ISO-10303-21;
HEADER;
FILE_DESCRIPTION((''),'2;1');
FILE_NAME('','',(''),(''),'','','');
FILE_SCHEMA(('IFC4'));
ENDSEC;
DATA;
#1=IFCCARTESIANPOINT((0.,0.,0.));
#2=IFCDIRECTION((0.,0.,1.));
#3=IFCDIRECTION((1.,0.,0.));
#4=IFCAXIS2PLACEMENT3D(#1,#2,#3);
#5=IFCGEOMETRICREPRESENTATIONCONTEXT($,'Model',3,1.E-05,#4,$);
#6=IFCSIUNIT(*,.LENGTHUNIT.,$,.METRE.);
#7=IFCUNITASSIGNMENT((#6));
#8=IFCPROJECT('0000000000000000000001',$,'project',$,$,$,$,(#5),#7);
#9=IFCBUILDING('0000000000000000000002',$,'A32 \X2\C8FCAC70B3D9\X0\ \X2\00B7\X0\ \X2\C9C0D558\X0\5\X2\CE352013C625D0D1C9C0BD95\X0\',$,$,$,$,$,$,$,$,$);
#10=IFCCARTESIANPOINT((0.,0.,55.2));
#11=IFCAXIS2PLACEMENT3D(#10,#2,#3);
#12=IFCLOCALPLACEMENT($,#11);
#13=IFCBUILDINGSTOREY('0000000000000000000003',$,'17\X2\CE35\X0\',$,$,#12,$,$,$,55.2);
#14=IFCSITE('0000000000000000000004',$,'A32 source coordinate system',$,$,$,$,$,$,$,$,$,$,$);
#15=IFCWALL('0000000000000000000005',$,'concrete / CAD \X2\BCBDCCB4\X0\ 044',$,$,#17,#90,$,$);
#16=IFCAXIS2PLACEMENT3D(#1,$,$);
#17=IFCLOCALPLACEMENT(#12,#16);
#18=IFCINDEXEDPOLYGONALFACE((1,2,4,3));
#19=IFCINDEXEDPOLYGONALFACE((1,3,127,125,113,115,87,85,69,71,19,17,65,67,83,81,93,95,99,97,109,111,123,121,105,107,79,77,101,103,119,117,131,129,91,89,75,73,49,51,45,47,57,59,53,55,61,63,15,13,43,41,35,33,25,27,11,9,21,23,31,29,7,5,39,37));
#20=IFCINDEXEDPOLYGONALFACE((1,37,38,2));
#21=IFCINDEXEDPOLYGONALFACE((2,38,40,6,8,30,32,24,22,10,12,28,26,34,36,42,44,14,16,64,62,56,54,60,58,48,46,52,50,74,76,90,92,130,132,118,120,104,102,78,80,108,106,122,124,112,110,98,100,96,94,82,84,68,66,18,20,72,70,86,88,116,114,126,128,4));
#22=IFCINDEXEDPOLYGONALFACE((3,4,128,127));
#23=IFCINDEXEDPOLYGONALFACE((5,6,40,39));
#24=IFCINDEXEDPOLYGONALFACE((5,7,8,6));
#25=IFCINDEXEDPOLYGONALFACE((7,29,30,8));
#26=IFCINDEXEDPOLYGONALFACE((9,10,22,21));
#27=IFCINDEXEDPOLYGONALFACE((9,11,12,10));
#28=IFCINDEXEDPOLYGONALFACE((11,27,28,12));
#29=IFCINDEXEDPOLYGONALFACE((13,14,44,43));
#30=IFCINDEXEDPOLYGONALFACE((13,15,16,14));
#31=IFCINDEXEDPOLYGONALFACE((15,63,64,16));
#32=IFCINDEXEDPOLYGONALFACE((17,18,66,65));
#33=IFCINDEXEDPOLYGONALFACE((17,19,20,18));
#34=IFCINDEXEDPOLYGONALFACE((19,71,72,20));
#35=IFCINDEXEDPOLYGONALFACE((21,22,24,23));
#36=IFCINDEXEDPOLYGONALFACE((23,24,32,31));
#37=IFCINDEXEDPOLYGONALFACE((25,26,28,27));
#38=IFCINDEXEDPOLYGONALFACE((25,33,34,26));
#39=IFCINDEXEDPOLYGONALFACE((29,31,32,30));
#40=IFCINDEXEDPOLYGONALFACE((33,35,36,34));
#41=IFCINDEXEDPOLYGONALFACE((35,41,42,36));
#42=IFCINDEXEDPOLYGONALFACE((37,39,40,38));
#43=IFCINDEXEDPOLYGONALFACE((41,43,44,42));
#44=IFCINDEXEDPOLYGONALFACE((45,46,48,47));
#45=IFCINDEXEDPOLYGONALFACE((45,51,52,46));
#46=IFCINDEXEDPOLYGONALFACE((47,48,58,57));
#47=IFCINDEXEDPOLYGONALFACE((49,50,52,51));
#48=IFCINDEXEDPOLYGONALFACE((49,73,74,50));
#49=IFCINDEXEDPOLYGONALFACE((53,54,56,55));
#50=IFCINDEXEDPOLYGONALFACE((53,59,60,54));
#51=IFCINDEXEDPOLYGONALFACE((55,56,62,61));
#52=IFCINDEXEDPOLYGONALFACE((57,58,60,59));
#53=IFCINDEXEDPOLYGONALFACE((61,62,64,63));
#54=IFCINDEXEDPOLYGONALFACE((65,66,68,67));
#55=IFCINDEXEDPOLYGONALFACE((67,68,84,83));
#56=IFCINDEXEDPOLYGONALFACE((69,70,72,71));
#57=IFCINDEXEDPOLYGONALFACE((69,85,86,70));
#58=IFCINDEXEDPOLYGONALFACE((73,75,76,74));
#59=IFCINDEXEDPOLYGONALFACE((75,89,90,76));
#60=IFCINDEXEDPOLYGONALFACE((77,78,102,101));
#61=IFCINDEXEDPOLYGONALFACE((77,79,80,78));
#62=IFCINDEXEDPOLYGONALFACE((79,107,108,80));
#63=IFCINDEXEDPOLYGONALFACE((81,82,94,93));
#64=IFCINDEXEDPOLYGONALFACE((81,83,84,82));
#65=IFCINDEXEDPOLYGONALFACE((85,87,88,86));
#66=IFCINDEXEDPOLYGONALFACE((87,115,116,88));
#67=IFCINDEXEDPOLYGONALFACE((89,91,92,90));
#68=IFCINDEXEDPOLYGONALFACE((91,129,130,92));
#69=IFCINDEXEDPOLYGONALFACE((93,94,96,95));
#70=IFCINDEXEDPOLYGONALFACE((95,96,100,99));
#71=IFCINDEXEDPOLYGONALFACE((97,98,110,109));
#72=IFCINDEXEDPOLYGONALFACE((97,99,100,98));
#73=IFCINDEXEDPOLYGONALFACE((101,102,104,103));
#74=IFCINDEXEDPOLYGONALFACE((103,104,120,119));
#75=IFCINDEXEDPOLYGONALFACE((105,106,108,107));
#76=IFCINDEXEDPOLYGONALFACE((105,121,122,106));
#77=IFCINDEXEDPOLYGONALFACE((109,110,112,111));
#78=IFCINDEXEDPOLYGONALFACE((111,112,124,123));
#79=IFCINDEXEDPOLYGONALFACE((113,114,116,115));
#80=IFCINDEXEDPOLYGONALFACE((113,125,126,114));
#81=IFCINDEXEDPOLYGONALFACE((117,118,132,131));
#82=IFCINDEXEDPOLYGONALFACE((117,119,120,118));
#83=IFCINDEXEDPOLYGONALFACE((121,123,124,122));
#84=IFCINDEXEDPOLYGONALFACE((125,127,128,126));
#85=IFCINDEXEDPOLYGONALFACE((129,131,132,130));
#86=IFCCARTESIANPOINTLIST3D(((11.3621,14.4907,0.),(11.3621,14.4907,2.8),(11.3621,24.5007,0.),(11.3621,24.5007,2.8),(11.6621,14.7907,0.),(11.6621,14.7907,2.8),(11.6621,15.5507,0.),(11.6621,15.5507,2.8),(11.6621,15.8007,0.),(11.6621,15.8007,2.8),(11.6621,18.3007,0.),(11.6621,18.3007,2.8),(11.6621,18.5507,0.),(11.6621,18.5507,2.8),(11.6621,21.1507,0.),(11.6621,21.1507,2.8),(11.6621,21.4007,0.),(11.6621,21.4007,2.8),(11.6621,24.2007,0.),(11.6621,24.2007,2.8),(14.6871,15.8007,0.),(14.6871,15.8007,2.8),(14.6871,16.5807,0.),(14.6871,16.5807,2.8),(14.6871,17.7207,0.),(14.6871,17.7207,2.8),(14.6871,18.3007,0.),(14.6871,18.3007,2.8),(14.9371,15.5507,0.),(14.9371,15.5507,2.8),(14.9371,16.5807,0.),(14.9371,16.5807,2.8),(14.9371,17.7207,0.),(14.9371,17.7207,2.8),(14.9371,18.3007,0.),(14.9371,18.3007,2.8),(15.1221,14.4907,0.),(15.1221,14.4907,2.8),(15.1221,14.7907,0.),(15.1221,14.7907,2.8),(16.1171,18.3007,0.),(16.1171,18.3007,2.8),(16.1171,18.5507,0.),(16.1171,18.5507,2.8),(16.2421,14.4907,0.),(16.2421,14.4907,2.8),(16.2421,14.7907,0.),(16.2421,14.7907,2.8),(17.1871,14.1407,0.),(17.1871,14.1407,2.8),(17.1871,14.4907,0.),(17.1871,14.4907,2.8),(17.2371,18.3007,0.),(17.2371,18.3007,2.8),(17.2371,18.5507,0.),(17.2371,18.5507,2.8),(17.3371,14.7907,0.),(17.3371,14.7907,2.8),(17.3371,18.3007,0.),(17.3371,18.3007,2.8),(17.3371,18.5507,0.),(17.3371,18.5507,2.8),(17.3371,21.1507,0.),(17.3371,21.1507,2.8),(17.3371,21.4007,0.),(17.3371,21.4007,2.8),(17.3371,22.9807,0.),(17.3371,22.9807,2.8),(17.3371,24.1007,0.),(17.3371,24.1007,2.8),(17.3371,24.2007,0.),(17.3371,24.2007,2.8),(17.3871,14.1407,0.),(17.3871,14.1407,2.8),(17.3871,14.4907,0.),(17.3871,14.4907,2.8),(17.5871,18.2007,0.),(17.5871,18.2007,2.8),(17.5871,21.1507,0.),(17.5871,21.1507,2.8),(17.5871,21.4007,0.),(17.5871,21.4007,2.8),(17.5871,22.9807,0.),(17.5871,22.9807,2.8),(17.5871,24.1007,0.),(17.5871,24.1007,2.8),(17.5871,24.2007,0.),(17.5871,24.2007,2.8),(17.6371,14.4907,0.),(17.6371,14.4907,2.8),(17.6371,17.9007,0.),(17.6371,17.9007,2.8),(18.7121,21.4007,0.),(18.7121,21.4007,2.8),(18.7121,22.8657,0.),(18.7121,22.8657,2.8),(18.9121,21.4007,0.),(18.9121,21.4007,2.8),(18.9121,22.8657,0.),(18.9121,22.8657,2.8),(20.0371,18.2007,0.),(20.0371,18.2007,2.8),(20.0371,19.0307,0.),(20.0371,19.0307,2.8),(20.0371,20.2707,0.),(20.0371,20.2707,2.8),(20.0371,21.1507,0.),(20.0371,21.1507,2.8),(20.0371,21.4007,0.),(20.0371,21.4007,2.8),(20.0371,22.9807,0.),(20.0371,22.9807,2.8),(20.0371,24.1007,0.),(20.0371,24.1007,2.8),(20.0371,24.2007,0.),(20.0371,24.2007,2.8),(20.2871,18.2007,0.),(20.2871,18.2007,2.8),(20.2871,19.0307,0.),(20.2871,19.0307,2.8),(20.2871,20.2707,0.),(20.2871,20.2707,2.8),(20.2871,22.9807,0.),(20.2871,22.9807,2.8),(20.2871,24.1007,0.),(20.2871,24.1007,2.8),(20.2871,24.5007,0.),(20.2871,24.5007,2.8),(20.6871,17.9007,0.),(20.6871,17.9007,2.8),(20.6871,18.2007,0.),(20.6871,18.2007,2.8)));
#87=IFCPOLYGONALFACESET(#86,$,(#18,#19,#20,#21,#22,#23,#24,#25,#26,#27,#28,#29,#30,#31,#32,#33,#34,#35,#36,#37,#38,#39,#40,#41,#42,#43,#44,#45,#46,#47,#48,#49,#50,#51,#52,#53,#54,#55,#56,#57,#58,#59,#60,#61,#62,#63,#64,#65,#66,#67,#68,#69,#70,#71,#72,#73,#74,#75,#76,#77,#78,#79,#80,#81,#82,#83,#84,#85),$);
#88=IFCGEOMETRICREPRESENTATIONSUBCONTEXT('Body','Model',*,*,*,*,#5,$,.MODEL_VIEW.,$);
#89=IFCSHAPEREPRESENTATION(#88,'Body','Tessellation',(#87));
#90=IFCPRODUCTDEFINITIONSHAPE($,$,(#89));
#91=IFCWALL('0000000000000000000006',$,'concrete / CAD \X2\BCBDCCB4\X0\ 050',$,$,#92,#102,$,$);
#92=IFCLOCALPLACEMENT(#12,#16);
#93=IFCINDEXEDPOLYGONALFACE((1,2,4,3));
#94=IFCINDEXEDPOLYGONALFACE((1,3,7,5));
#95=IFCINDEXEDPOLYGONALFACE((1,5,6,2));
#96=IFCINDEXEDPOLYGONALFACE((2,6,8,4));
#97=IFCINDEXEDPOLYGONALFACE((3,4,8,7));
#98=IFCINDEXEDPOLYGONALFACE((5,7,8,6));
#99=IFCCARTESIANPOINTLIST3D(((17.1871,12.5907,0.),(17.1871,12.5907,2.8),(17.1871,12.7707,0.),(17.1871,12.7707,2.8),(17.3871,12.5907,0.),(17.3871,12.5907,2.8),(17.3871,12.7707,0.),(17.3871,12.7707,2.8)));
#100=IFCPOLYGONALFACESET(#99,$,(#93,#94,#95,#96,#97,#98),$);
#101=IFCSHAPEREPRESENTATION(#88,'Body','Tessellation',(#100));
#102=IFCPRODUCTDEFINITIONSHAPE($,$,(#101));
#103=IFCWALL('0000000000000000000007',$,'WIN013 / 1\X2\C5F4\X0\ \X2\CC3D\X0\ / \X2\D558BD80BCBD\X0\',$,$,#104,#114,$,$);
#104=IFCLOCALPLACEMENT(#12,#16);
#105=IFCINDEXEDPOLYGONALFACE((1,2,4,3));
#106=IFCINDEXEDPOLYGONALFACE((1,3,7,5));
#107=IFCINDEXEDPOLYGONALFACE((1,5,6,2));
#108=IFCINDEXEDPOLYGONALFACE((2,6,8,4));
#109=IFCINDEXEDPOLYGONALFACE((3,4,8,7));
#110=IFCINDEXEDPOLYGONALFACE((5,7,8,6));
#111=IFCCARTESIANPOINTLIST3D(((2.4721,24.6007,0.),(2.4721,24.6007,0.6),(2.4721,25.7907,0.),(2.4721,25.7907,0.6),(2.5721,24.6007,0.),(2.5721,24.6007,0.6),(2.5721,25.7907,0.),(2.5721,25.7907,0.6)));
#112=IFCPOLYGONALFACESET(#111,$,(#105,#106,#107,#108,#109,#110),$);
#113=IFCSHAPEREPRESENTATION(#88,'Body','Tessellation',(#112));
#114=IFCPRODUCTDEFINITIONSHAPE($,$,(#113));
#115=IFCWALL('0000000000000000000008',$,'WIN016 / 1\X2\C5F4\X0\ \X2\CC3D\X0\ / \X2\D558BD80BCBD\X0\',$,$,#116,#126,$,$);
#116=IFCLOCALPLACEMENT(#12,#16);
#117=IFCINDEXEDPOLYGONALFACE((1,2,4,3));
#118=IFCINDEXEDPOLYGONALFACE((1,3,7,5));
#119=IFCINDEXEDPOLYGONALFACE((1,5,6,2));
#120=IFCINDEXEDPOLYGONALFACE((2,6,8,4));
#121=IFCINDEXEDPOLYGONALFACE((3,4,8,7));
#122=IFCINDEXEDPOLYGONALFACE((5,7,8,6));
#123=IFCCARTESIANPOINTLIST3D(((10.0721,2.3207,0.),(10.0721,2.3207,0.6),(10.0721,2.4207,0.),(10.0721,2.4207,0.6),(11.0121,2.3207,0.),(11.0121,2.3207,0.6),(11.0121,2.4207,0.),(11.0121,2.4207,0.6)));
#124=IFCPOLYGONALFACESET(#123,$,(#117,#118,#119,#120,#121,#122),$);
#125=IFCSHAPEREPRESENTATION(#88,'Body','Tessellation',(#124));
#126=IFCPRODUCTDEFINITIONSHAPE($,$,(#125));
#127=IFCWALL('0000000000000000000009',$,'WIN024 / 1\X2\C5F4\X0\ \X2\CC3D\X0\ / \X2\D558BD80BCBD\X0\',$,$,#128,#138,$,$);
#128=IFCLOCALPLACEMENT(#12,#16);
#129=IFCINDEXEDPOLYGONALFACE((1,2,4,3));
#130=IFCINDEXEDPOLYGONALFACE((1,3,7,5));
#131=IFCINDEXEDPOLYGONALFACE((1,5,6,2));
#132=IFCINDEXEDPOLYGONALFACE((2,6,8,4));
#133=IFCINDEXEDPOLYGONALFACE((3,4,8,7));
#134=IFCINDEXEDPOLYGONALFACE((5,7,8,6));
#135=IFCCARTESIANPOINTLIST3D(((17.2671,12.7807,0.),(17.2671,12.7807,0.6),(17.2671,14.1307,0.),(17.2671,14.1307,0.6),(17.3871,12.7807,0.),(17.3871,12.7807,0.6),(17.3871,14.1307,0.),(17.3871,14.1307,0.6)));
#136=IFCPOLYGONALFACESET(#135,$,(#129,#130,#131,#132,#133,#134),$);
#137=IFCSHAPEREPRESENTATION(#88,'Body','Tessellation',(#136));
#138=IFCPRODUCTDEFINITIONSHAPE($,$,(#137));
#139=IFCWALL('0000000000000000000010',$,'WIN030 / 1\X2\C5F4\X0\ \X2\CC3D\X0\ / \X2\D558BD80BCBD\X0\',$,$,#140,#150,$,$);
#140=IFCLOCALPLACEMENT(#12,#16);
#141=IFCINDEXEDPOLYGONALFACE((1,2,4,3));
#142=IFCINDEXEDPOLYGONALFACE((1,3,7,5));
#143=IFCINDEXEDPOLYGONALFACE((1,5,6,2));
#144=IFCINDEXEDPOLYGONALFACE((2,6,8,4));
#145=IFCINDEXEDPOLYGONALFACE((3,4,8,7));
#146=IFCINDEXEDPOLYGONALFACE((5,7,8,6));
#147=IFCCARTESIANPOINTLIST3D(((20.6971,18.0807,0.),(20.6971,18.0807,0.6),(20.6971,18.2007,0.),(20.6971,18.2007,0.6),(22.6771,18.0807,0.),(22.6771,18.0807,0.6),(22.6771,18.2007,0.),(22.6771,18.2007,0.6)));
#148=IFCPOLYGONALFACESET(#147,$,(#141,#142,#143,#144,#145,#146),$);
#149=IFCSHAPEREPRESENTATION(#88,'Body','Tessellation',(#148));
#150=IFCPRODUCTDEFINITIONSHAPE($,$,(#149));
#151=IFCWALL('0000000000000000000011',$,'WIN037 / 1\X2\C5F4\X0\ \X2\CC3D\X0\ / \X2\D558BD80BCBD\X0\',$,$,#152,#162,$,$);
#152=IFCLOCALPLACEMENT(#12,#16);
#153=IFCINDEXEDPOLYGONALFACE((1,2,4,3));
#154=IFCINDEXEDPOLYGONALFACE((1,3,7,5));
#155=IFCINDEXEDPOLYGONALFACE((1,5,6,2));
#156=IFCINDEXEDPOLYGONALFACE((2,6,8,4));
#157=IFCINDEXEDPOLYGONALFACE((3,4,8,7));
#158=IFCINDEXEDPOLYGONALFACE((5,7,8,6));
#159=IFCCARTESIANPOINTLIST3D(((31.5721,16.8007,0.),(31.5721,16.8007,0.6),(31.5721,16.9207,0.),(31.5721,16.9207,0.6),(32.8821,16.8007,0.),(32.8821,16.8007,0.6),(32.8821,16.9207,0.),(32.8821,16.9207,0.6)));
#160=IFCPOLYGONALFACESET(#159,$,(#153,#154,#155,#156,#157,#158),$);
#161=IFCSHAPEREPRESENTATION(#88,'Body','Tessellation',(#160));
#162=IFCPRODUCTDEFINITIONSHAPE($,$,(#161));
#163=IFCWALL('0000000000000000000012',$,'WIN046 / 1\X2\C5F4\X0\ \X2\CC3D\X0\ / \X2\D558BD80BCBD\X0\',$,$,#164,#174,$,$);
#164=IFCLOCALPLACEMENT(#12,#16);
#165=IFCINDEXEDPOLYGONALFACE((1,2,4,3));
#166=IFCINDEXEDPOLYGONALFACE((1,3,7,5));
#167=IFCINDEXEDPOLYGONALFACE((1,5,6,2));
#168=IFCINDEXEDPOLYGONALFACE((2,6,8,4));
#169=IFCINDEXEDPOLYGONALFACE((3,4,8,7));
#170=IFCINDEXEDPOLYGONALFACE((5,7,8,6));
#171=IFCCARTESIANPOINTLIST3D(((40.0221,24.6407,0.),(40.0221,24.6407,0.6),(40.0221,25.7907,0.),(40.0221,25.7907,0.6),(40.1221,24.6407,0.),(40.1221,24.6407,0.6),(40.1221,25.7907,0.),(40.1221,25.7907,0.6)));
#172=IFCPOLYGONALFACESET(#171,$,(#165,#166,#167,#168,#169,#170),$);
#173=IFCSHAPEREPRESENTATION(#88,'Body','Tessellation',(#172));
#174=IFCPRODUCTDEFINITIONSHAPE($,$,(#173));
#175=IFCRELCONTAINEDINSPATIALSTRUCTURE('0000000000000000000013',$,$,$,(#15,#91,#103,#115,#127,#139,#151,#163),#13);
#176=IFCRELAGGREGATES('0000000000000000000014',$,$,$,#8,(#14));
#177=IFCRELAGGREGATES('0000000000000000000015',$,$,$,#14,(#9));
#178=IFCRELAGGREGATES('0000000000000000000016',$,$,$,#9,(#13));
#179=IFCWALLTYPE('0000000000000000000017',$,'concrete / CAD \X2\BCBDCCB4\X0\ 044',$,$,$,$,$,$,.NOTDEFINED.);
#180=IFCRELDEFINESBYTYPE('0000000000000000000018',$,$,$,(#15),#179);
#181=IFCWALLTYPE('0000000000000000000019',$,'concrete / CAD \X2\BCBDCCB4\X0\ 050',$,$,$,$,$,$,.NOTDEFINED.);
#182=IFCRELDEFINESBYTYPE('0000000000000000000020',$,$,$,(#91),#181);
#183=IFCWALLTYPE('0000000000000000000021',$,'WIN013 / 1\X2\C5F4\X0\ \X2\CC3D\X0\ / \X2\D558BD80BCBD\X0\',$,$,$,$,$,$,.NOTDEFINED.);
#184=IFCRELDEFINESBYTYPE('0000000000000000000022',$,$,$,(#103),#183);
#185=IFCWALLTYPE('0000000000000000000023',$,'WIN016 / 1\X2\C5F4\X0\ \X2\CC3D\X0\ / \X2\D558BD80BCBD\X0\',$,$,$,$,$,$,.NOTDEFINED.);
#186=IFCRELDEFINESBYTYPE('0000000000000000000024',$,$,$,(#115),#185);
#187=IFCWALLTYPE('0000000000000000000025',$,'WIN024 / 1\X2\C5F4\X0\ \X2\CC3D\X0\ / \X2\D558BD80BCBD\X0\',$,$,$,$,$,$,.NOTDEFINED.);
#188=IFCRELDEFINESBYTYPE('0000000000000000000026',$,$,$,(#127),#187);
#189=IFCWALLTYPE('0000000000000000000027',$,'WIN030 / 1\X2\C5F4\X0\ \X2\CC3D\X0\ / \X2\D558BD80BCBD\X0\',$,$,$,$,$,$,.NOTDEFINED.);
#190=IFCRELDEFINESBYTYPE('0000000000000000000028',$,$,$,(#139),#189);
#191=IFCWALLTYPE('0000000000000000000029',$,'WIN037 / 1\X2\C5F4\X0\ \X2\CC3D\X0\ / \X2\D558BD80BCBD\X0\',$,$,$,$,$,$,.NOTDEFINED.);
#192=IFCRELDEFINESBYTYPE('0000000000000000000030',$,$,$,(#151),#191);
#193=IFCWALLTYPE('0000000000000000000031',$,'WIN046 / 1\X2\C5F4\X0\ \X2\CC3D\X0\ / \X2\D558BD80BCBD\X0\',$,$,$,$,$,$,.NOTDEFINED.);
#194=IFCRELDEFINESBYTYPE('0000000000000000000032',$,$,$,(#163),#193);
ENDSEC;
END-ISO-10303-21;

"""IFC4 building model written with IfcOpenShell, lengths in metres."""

from ifc_helpers import new_model, si_unit, frame, origin, origin_with_axes, place, context, subcontext, project, spatial, polyline, outline, extrude, source, transform, mapped, type_object, type_shapes, element, save


model = new_model("IFC4")

# Units and contexts
model_context = context("Model", 3, precision=1e-05, world=origin_with_axes())
body_context = subcontext(model_context, "Body", "Model", "MODEL_VIEW")
ifc_project = project(units=[si_unit("LENGTHUNIT", "METRE")], contexts=[model_context])

# Site, building, storey
site = spatial("IfcSite", under=ifc_project, Name="A32 source coordinate system")
building = spatial("IfcBuilding", under=site, Name="A32 주거동 · 지하5층–옥탑지붕")
storey_placement = place(None, frame((0.0, 0.0, 55.2), z_axis=(0.0, 0.0, 1.0), x_axis=(1.0, 0.0, 0.0)))
storey = spatial("IfcBuildingStorey", under=building, at=storey_placement, Name="17층", Elevation=55.2)

# Walls
wall_type_1 = type_object("IfcWallType", Name="concrete / CAD 벽체 044", PredefinedType="NOTDEFINED")
shared_shape_1 = source(origin(), body_context, "Body", "SweptSolid", [
    extrude(outline(polyline([(17.3371, 21.4007), (17.3371, 22.9807), (17.5871, 22.9807), (17.5871, 21.4007), (18.7121, 21.4007), (18.7121, 22.8657), (18.9121, 22.8657), (18.9121, 21.4007), (20.0371, 21.4007), (20.0371, 22.9807), (20.2871, 22.9807), (20.2871, 20.2707), (20.0371, 20.2707), (20.0371, 21.1507), (17.5871, 21.1507), (17.5871, 18.2007), (20.0371, 18.2007), (20.0371, 19.0307), (20.2871, 19.0307), (20.2871, 18.2007), (20.6871, 18.2007), (20.6871, 17.9007), (17.6371, 17.9007), (17.6371, 14.4907), (17.3871, 14.4907), (17.3871, 14.1407), (17.1871, 14.1407), (17.1871, 14.4907), (16.2421, 14.4907), (16.2421, 14.7907), (17.3371, 14.7907), (17.3371, 18.3007), (17.2371, 18.3007), (17.2371, 18.5507), (17.3371, 18.5507), (17.3371, 21.1507), (11.6621, 21.1507), (11.6621, 18.5507), (16.1171, 18.5507), (16.1171, 18.3007), (14.9371, 18.3007), (14.9371, 17.7207), (14.6871, 17.7207), (14.6871, 18.3007), (11.6621, 18.3007), (11.6621, 15.8007), (14.6871, 15.8007), (14.6871, 16.5807), (14.9371, 16.5807), (14.9371, 15.5507), (11.6621, 15.5507), (11.6621, 14.7907), (15.1221, 14.7907), (15.1221, 14.4907), (11.3621, 14.4907), (11.3621, 24.5007), (20.2871, 24.5007), (20.2871, 24.1007), (20.0371, 24.1007), (20.0371, 24.2007), (17.5871, 24.2007), (17.5871, 24.1007), (17.3371, 24.1007), (17.3371, 24.2007), (11.6621, 24.2007), (11.6621, 21.4007), (17.3371, 21.4007)])), origin(), (0.0, 0.0, 1.0), 2.8),
])
type_shapes(wall_type_1, [shared_shape_1])
wall_1_placement = place(storey_placement, origin_with_axes())
element("IfcWall", 1, at=wall_1_placement, inside=storey, type_object=wall_type_1, Name="concrete / CAD 벽체 044", context=body_context, shape_type="MappedRepresentation", body=[
    mapped(shared_shape_1, transform((0.0, 0.0, 0.0), scale=1.0)),
])
wall_type_2 = type_object("IfcWallType", Name="concrete / CAD 벽체 050", PredefinedType="NOTDEFINED")
shared_shape_2 = source(origin(), body_context, "Body", "SweptSolid", [
    extrude(outline(polyline([(17.3871, 12.5907), (17.1871, 12.5907), (17.1871, 12.7707), (17.3871, 12.7707), (17.3871, 12.5907)])), origin(), (0.0, 0.0, 1.0), 2.8),
])
type_shapes(wall_type_2, [shared_shape_2])
wall_2_placement = place(storey_placement, origin_with_axes())
element("IfcWall", 2, at=wall_2_placement, inside=storey, type_object=wall_type_2, Name="concrete / CAD 벽체 050", context=body_context, shape_type="MappedRepresentation", body=[
    mapped(shared_shape_2, transform((0.0, 0.0, 0.0), scale=1.0)),
])
wall_type_3 = type_object("IfcWallType", Name="WIN013 / 1열 창 / 하부벽", PredefinedType="NOTDEFINED")
shared_shape_3 = source(origin(), body_context, "Body", "SweptSolid", [
    extrude(outline(polyline([(2.5721, 25.7907), (2.5721, 24.6007), (2.4721, 24.6007), (2.4721, 25.7907), (2.5721, 25.7907)])), origin(), (0.0, 0.0, 1.0), 0.6),
])
type_shapes(wall_type_3, [shared_shape_3])
wall_3_placement = place(storey_placement, origin_with_axes())
element("IfcWall", 3, at=wall_3_placement, inside=storey, type_object=wall_type_3, Name="WIN013 / 1열 창 / 하부벽", context=body_context, shape_type="MappedRepresentation", body=[
    mapped(shared_shape_3, transform((0.0, 0.0, 0.0), scale=1.0)),
])
wall_type_4 = type_object("IfcWallType", Name="WIN016 / 1열 창 / 하부벽", PredefinedType="NOTDEFINED")
shared_shape_4 = source(origin(), body_context, "Body", "SweptSolid", [
    extrude(outline(polyline([(11.0121, 2.4207), (11.0121, 2.3207), (10.0721, 2.3207), (10.0721, 2.4207), (11.0121, 2.4207)])), origin(), (0.0, 0.0, 1.0), 0.6),
])
type_shapes(wall_type_4, [shared_shape_4])
wall_4_placement = place(storey_placement, origin_with_axes())
element("IfcWall", 4, at=wall_4_placement, inside=storey, type_object=wall_type_4, Name="WIN016 / 1열 창 / 하부벽", context=body_context, shape_type="MappedRepresentation", body=[
    mapped(shared_shape_4, transform((0.0, 0.0, 0.0), scale=1.0)),
])
wall_type_5 = type_object("IfcWallType", Name="WIN024 / 1열 창 / 하부벽", PredefinedType="NOTDEFINED")
shared_shape_5 = source(origin(), body_context, "Body", "SweptSolid", [
    extrude(outline(polyline([(17.3871, 14.1307), (17.3871, 12.7807), (17.2671, 12.7807), (17.2671, 14.1307), (17.3871, 14.1307)])), origin(), (0.0, 0.0, 1.0), 0.6),
])
type_shapes(wall_type_5, [shared_shape_5])
wall_5_placement = place(storey_placement, origin_with_axes())
element("IfcWall", 5, at=wall_5_placement, inside=storey, type_object=wall_type_5, Name="WIN024 / 1열 창 / 하부벽", context=body_context, shape_type="MappedRepresentation", body=[
    mapped(shared_shape_5, transform((0.0, 0.0, 0.0), scale=1.0)),
])
wall_type_6 = type_object("IfcWallType", Name="WIN030 / 1열 창 / 하부벽", PredefinedType="NOTDEFINED")
shared_shape_6 = source(origin(), body_context, "Body", "SweptSolid", [
    extrude(outline(polyline([(22.6771, 18.2007), (22.6771, 18.0807), (20.6971, 18.0807), (20.6971, 18.2007), (22.6771, 18.2007)])), origin(), (0.0, 0.0, 1.0), 0.6),
])
type_shapes(wall_type_6, [shared_shape_6])
wall_6_placement = place(storey_placement, origin_with_axes())
element("IfcWall", 6, at=wall_6_placement, inside=storey, type_object=wall_type_6, Name="WIN030 / 1열 창 / 하부벽", context=body_context, shape_type="MappedRepresentation", body=[
    mapped(shared_shape_6, transform((0.0, 0.0, 0.0), scale=1.0)),
])
wall_type_7 = type_object("IfcWallType", Name="WIN037 / 1열 창 / 하부벽", PredefinedType="NOTDEFINED")
shared_shape_7 = source(origin(), body_context, "Body", "SweptSolid", [
    extrude(outline(polyline([(32.8821, 16.9207), (32.8821, 16.8007), (31.5721, 16.8007), (31.5721, 16.9207), (32.8821, 16.9207)])), origin(), (0.0, 0.0, 1.0), 0.6),
])
type_shapes(wall_type_7, [shared_shape_7])
wall_7_placement = place(storey_placement, origin_with_axes())
element("IfcWall", 7, at=wall_7_placement, inside=storey, type_object=wall_type_7, Name="WIN037 / 1열 창 / 하부벽", context=body_context, shape_type="MappedRepresentation", body=[
    mapped(shared_shape_7, transform((0.0, 0.0, 0.0), scale=1.0)),
])
wall_type_8 = type_object("IfcWallType", Name="WIN046 / 1열 창 / 하부벽", PredefinedType="NOTDEFINED")
shared_shape_8 = source(origin(), body_context, "Body", "SweptSolid", [
    extrude(outline(polyline([(40.1221, 25.7907), (40.1221, 24.6407), (40.0221, 24.6407), (40.0221, 25.7907), (40.1221, 25.7907)])), origin(), (0.0, 0.0, 1.0), 0.6),
])
type_shapes(wall_type_8, [shared_shape_8])
wall_8_placement = place(storey_placement, origin_with_axes())
element("IfcWall", 8, at=wall_8_placement, inside=storey, type_object=wall_type_8, Name="WIN046 / 1열 창 / 하부벽", context=body_context, shape_type="MappedRepresentation", body=[
    mapped(shared_shape_8, transform((0.0, 0.0, 0.0), scale=1.0)),
])

save(model, "model.ifc")
